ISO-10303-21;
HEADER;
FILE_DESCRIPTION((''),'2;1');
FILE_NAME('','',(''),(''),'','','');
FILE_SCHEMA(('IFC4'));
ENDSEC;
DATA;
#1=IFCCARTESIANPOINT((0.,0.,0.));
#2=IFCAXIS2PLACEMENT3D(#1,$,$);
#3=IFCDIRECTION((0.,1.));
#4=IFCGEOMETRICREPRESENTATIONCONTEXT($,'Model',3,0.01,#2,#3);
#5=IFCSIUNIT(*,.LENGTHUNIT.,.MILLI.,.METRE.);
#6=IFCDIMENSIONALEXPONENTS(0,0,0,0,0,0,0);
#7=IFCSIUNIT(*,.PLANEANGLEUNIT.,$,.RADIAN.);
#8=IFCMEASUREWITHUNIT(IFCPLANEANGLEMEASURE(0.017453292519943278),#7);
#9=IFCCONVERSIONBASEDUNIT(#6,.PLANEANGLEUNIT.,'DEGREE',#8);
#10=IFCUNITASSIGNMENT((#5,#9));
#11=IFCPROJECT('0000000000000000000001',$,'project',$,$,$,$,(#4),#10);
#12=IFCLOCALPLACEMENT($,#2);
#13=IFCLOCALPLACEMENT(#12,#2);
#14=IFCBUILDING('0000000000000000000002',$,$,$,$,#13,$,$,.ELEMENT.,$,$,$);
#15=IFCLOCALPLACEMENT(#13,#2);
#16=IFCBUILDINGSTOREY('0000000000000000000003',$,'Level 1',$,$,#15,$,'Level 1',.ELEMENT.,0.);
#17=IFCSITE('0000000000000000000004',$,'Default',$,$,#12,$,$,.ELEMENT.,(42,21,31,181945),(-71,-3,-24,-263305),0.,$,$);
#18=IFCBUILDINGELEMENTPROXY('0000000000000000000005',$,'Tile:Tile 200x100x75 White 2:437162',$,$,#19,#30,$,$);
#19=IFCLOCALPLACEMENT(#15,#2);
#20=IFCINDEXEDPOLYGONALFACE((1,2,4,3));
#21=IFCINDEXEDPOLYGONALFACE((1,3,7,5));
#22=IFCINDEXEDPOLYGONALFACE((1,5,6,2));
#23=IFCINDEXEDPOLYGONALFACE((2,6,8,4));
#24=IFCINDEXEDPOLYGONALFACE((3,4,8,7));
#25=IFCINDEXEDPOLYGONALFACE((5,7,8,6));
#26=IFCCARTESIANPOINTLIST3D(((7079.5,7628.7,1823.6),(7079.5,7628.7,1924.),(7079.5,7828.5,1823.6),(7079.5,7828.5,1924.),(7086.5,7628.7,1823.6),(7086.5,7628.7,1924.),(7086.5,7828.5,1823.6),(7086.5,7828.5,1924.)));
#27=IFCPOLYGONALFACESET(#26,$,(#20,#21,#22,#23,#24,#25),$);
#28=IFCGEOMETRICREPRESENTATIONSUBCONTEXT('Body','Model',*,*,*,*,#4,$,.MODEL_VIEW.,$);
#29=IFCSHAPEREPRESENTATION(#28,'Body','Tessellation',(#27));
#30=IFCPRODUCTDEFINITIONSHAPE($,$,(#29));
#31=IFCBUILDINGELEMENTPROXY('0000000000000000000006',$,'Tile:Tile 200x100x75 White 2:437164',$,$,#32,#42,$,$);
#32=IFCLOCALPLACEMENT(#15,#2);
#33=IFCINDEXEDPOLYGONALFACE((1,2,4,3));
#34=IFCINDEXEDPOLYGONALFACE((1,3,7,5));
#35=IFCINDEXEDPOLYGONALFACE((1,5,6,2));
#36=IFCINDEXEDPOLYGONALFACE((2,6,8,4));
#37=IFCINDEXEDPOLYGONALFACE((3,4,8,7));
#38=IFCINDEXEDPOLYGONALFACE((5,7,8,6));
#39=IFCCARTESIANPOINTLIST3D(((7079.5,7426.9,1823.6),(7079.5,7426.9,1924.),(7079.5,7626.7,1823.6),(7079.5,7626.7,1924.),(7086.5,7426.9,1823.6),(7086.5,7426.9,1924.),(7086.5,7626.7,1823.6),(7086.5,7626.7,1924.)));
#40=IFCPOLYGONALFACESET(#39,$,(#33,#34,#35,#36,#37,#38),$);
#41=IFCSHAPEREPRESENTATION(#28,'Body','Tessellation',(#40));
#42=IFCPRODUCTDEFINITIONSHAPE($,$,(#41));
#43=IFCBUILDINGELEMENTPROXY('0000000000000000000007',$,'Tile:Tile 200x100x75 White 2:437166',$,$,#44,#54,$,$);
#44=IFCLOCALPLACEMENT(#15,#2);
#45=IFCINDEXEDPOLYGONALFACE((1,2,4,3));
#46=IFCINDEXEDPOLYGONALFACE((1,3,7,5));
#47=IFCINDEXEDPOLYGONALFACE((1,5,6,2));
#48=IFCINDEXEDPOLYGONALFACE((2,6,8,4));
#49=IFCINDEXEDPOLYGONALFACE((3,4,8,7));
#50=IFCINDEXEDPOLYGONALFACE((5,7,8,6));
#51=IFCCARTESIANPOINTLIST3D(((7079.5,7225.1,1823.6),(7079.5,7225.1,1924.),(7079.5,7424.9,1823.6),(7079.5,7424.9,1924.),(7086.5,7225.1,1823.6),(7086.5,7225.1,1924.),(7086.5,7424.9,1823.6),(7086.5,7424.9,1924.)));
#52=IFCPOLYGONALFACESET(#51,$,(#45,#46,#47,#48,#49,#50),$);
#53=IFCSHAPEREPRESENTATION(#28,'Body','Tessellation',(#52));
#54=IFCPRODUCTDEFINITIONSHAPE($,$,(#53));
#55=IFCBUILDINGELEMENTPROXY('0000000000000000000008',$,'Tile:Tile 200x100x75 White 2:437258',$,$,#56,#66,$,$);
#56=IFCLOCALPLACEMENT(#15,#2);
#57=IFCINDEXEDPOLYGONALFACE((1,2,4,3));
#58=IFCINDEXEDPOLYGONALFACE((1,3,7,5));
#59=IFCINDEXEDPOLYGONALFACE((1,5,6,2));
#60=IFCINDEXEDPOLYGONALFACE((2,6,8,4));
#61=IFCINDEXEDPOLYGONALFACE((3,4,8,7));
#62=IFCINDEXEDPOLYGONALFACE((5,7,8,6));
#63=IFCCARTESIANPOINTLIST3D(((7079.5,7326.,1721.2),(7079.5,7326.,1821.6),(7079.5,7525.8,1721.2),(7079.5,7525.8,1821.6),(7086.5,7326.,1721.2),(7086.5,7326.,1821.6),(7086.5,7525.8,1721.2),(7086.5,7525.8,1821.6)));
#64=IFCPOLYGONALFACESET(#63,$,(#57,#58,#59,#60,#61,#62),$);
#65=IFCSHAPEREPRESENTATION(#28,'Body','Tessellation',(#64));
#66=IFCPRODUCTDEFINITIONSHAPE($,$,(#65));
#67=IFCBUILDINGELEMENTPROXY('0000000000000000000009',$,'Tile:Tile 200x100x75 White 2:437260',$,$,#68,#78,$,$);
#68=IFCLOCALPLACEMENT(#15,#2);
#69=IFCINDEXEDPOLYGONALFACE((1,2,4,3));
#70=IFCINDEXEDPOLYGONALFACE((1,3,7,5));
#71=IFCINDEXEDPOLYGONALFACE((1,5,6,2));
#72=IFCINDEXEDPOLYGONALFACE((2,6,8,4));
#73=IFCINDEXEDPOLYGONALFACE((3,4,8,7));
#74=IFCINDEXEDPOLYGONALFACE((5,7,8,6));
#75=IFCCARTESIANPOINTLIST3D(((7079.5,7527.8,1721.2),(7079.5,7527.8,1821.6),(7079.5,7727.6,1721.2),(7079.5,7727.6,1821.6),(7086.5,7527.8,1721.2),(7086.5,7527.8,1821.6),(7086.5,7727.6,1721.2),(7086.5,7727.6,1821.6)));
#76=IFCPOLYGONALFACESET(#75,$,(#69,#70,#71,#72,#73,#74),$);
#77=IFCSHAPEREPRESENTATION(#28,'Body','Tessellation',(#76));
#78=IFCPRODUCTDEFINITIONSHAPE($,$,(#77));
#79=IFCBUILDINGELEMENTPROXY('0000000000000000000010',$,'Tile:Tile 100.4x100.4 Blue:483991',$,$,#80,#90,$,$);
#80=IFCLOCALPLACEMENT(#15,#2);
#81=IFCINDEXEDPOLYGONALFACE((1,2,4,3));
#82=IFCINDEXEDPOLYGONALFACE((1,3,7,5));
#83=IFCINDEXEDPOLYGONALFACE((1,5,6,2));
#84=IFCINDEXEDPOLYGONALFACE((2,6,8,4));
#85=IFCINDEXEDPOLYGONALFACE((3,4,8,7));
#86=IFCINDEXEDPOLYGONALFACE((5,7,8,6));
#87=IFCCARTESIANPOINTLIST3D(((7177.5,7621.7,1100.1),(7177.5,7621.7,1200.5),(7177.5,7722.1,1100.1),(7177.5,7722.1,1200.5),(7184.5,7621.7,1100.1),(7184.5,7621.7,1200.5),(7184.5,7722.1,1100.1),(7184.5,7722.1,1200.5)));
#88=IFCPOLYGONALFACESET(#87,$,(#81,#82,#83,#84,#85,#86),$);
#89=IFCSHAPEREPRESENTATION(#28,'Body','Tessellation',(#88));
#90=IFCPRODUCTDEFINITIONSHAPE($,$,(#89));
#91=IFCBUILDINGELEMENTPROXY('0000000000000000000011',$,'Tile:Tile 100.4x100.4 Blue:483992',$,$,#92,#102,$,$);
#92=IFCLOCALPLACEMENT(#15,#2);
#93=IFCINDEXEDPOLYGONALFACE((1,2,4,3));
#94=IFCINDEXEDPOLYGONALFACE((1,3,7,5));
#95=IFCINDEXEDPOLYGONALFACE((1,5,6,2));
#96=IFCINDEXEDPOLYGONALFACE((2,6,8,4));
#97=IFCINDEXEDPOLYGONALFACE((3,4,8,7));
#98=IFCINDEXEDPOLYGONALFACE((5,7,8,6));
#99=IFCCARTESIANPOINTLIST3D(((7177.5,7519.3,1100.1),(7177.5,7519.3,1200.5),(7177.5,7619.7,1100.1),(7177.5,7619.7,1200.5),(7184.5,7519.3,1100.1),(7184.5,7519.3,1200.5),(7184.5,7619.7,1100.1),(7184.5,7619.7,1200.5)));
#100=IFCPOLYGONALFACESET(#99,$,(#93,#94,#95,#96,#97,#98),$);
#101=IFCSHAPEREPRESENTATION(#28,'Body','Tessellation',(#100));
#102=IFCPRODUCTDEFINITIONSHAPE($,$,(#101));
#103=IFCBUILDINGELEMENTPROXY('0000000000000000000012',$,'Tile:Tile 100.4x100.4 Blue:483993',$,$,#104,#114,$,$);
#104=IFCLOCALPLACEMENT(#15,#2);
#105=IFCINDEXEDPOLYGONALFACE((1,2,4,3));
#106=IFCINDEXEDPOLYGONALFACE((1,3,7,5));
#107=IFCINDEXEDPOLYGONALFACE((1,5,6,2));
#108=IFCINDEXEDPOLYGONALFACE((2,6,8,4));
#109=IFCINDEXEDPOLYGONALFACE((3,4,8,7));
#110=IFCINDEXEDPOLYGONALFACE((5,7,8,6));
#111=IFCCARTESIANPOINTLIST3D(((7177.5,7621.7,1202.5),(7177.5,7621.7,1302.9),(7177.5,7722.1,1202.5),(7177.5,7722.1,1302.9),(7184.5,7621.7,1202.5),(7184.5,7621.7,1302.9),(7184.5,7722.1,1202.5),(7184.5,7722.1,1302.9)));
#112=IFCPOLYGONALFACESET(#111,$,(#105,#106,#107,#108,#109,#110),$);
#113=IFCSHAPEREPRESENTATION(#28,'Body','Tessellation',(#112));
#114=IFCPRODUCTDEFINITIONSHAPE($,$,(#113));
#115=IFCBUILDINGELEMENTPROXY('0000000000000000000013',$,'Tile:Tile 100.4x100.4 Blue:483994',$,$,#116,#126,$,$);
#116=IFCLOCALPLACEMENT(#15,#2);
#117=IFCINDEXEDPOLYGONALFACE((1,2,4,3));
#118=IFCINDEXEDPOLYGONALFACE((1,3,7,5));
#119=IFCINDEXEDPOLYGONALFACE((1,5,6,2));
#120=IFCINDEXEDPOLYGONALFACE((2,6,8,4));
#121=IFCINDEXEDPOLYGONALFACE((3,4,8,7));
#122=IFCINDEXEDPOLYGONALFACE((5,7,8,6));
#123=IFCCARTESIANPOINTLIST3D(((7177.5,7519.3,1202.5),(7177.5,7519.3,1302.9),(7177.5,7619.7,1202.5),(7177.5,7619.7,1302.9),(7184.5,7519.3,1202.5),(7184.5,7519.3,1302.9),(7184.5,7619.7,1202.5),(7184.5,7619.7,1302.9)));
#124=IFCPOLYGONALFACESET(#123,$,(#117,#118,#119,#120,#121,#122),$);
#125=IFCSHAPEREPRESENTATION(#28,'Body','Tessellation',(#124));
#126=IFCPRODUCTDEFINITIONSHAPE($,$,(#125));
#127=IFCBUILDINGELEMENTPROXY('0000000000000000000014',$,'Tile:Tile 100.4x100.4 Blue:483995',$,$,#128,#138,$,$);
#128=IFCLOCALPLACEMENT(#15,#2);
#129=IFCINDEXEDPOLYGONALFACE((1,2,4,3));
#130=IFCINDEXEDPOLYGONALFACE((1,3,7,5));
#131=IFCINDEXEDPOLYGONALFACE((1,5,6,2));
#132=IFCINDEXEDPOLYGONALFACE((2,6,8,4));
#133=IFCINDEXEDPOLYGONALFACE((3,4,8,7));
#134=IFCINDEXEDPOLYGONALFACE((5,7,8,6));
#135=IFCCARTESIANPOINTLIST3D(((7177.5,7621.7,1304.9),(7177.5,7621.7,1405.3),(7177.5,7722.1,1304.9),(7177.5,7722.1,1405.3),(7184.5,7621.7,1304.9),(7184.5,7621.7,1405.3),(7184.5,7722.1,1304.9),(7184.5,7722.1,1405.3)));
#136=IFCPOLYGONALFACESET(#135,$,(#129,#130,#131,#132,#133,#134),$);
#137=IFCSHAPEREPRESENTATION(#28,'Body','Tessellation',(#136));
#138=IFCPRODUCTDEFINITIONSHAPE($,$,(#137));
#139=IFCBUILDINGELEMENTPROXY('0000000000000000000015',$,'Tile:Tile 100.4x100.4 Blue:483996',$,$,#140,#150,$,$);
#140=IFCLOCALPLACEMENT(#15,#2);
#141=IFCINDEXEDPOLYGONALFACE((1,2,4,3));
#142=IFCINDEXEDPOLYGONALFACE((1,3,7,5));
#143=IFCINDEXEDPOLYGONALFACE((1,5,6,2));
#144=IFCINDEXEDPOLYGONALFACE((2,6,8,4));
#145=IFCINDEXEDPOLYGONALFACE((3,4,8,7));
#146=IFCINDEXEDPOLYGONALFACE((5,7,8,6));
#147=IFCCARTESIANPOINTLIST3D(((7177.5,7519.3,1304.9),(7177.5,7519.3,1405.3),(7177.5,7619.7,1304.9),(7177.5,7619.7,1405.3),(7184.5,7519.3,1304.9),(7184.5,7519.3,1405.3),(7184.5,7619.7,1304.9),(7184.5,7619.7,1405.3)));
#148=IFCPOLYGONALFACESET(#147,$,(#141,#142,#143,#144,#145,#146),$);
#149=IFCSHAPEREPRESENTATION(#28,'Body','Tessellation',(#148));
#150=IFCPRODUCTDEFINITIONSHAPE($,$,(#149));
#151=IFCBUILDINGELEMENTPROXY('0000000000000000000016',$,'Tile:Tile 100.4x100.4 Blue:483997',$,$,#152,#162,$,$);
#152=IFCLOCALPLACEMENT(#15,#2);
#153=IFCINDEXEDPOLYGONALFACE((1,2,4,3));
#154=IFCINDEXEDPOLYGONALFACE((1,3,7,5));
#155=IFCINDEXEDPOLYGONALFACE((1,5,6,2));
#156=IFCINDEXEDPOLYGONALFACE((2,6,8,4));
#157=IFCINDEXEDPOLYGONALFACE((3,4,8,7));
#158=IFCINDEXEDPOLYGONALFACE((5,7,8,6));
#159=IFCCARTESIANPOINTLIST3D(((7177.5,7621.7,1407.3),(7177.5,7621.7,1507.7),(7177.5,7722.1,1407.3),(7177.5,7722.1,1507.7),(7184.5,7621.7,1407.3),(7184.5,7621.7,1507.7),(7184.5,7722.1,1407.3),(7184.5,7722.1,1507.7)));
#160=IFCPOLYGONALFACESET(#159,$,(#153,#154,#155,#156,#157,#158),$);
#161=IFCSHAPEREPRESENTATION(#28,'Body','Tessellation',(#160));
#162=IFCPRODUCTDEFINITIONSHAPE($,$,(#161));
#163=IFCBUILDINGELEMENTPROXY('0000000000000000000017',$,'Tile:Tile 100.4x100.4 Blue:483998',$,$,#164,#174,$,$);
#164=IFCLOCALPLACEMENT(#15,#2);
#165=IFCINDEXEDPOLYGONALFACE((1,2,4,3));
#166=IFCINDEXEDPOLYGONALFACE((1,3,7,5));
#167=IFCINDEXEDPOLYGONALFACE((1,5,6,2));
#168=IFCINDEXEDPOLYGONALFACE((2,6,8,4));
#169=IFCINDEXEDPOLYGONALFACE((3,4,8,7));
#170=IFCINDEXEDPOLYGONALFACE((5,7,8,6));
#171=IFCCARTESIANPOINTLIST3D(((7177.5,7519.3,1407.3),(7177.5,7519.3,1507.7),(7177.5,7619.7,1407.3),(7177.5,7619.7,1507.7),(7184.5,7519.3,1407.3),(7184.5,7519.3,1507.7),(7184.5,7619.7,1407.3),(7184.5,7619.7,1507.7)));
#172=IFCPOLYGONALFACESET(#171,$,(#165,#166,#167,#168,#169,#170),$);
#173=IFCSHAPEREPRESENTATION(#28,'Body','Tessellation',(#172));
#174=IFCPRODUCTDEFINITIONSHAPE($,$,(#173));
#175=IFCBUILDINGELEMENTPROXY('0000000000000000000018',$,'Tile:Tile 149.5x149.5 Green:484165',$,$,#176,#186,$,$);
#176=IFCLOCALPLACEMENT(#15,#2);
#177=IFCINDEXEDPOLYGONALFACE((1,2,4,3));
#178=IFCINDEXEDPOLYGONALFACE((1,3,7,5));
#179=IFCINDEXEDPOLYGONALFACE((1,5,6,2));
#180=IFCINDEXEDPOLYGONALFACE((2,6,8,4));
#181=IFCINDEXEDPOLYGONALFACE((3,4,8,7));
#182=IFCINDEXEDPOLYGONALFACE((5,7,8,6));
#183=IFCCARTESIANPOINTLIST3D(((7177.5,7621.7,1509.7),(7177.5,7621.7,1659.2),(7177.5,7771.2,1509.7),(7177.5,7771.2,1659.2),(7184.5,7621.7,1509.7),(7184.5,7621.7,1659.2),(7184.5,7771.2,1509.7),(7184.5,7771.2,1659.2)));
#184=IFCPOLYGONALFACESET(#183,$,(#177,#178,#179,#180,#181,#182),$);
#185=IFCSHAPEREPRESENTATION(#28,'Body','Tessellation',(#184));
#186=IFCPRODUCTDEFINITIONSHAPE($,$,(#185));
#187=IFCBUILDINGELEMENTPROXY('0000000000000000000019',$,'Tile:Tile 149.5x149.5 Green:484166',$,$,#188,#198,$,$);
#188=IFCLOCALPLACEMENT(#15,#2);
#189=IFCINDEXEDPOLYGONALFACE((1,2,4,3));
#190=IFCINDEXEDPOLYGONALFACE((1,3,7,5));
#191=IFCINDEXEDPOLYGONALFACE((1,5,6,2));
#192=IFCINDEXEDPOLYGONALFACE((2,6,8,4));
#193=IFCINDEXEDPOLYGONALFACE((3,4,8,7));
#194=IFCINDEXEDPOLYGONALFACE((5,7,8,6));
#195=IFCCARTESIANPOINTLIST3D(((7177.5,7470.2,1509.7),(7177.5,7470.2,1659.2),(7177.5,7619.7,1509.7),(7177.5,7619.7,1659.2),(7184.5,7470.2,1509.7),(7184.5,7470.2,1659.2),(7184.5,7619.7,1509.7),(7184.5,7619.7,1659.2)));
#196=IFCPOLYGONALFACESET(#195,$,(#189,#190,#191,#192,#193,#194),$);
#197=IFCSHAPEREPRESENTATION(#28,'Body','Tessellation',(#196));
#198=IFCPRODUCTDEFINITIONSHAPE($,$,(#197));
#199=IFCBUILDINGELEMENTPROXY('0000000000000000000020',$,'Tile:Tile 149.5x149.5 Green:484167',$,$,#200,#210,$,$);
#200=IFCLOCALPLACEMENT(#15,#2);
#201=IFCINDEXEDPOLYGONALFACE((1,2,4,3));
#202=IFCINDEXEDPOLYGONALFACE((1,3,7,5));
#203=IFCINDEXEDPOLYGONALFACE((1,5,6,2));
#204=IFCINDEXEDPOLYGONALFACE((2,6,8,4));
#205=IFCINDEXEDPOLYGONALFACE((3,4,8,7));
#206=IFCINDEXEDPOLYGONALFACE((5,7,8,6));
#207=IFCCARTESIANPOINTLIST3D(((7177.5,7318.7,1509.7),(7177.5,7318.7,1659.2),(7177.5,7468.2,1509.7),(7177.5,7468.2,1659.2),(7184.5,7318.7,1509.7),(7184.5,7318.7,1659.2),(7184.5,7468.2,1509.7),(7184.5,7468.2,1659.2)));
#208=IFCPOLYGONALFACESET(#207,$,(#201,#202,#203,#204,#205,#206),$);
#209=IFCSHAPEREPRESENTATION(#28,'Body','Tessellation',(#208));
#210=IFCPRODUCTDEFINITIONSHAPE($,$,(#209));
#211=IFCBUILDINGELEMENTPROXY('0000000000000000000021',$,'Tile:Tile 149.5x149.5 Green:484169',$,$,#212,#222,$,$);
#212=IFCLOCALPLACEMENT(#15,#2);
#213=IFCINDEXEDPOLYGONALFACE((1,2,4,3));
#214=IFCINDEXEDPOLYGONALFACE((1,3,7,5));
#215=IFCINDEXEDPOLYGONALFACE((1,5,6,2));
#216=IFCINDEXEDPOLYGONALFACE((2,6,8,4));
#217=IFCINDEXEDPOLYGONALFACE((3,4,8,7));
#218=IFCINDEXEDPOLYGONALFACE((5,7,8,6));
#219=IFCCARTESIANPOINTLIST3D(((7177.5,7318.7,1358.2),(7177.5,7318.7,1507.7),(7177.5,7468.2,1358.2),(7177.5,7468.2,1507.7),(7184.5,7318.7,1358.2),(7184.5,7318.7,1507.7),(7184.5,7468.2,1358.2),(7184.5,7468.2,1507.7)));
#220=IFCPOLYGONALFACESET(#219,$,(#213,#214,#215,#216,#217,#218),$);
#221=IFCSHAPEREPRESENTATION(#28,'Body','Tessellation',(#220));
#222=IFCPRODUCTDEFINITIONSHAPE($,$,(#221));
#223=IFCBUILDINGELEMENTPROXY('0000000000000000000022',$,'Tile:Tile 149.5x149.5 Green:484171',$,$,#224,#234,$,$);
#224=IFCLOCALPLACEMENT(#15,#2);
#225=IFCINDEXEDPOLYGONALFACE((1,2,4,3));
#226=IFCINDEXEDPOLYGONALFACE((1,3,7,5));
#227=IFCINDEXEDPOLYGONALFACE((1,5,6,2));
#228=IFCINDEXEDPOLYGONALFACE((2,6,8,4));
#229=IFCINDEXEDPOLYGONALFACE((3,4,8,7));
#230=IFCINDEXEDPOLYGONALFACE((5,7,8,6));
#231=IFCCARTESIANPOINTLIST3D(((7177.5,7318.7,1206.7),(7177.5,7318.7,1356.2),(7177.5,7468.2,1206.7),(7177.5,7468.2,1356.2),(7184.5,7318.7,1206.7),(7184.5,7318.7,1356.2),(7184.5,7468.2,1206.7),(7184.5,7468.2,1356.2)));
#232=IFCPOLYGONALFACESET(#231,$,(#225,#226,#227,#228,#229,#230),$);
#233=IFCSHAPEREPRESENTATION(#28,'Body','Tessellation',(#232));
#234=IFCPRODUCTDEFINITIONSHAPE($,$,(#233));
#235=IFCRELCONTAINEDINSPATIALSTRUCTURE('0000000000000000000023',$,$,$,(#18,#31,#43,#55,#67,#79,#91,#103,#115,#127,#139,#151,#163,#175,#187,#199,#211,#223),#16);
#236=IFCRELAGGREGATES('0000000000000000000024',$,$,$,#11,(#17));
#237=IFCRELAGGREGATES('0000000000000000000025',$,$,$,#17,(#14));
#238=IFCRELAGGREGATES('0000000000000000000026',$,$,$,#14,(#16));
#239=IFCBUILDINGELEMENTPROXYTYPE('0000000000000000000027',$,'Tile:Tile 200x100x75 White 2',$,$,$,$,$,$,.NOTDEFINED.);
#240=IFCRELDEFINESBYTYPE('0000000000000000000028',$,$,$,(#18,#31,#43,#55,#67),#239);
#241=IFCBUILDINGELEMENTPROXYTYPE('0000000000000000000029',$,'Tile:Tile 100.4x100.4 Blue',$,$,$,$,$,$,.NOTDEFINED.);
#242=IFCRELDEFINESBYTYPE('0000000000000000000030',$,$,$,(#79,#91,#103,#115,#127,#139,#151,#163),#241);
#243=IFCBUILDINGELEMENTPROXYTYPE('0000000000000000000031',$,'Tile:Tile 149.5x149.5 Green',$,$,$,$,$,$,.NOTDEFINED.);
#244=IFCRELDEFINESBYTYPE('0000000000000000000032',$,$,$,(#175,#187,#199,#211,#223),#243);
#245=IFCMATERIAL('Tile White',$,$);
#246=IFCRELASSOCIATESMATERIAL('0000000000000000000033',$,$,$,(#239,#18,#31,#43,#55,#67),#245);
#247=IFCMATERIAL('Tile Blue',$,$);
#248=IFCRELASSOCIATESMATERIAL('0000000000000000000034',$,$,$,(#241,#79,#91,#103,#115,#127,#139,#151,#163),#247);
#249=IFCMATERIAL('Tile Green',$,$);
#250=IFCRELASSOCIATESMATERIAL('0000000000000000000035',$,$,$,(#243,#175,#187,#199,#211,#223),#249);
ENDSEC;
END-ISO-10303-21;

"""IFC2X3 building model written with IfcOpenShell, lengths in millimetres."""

from ifc_helpers import new_model, entity, si_unit, converted_unit, direction, frame, frame_2d, origin, origin_2d_with_axis, place, context, subcontext, project, spatial, rectangle, extrude, source, transform, mapped, material, type_object, type_shapes, element, save


model = new_model("IFC2X3")

# Units and contexts
model_context = context("Model", 3, precision=0.01, world=origin(), true_north=direction((0.0, 1.0)))
body_context = subcontext(model_context, "Body", "Model", "MODEL_VIEW")
ifc_project = project(units=[si_unit("LENGTHUNIT", "METRE", prefix="MILLI"), converted_unit("PLANEANGLEUNIT", "DEGREE", entity("IfcPlaneAngleMeasure", 0.017453292519943278), si_unit("PLANEANGLEUNIT", "RADIAN"), dimensions=[0, 0, 0, 0, 0, 0, 0])], contexts=[model_context])

# Site, building, storey
site_placement = place(None, origin())
site = spatial("IfcSite", under=ifc_project, at=site_placement, Name="Default", CompositionType="ELEMENT", RefLatitude=(42, 21, 31, 181945), RefLongitude=(-71, -3, -24, -263305), RefElevation=0.0)
building_placement = place(site_placement, origin())
building = spatial("IfcBuilding", under=site, at=building_placement, CompositionType="ELEMENT")
storey_placement = place(building_placement, origin())
storey = spatial("IfcBuildingStorey", under=building, at=storey_placement, Name="Level 1", LongName="Level 1", CompositionType="ELEMENT", Elevation=0.0)

# Building element proxies
ifc_material_1 = material(Name="Tile White")
building_element_proxy_type_1 = type_object("IfcBuildingElementProxyType", Name="Tile:Tile 200x100x75 White 2", PredefinedType="NOTDEFINED", material=ifc_material_1)
shared_shape_1 = source(origin(), body_context, "Body", "SweptSolid", [
    extrude(rectangle(XDim=199.8, YDim=100.4, at=frame_2d((0.0, 0.0), x_axis=(1.0, 0.0))), frame((-50.2, -99.9, 0.0), z_axis=(0.0, 0.0, 1.0), x_axis=(0.0, -1.0, 0.0)), (0.0, 0.0, 1.0), 7.0),
])
type_shapes(building_element_proxy_type_1, [shared_shape_1])
for number, where, z_axis, x_axis, name in (
    (1, (7086.5, 7828.5, 1924.0), (-1.0, 0.0, 0.0), (0.0, 0.0, 1.0), "Tile:Tile 200x100x75 White 2:437162"),
    (2, (7086.5, 7626.7, 1924.0), (-1.0, 0.0, 0.0), (0.0, 0.0, 1.0), "Tile:Tile 200x100x75 White 2:437164"),
    (3, (7086.5, 7424.9, 1924.0), (-1.0, 0.0, 0.0), (0.0, 0.0, 1.0), "Tile:Tile 200x100x75 White 2:437166"),
    (4, (7086.5, 7525.8, 1821.6), (-1.0, 0.0, 0.0), (0.0, 0.0, 1.0), "Tile:Tile 200x100x75 White 2:437258"),
    (5, (7086.5, 7727.6, 1821.6), (-1.0, 0.0, 0.0), (0.0, 0.0, 1.0), "Tile:Tile 200x100x75 White 2:437260"),
):
    element("IfcBuildingElementProxy", number, at=place(storey_placement, frame(where, z_axis=z_axis, x_axis=x_axis)), inside=storey, type_object=building_element_proxy_type_1, material=ifc_material_1, Name=name, context=body_context, shape_type="MappedRepresentation", body=[
        mapped(shared_shape_1, transform((0.0, 0.0, 0.0), scale=1.0)),
    ])
ifc_material_2 = material(Name="Tile Blue")
building_element_proxy_type_2 = type_object("IfcBuildingElementProxyType", Name="Tile:Tile 100.4x100.4 Blue", PredefinedType="NOTDEFINED", material=ifc_material_2)
shared_shape_2 = source(origin(), body_context, "Body", "SweptSolid", [
    extrude(rectangle(XDim=100.4, YDim=100.4, at=origin_2d_with_axis()), frame((-50.2, -50.2, 0.0), z_axis=(0.0, 0.0, 1.0), x_axis=(0.0, -1.0, 0.0)), (0.0, 0.0, 1.0), 7.0),
])
type_shapes(building_element_proxy_type_2, [shared_shape_2])
for number, where, z_axis, x_axis, name in (
    (6, (7184.5, 7722.1, 1100.1), (-1.0, 0.0, 0.0), (0.0, 1.0, 0.0), "Tile:Tile 100.4x100.4 Blue:483991"),
    (7, (7184.5, 7619.7, 1100.1), (-1.0, 0.0, 0.0), (0.0, 1.0, 0.0), "Tile:Tile 100.4x100.4 Blue:483992"),
    (8, (7184.5, 7722.1, 1202.5), (-1.0, 0.0, 0.0), (0.0, 1.0, 0.0), "Tile:Tile 100.4x100.4 Blue:483993"),
    (9, (7184.5, 7619.7, 1202.5), (-1.0, 0.0, 0.0), (0.0, 1.0, 0.0), "Tile:Tile 100.4x100.4 Blue:483994"),
    (10, (7184.5, 7722.1, 1304.9), (-1.0, 0.0, 0.0), (0.0, 1.0, 0.0), "Tile:Tile 100.4x100.4 Blue:483995"),
    (11, (7184.5, 7619.7, 1304.9), (-1.0, 0.0, 0.0), (0.0, 1.0, 0.0), "Tile:Tile 100.4x100.4 Blue:483996"),
    (12, (7184.5, 7722.1, 1407.3), (-1.0, 0.0, 0.0), (0.0, 1.0, 0.0), "Tile:Tile 100.4x100.4 Blue:483997"),
    (13, (7184.5, 7619.7, 1407.3), (-1.0, 0.0, 0.0), (0.0, 1.0, 0.0), "Tile:Tile 100.4x100.4 Blue:483998"),
):
    element("IfcBuildingElementProxy", number, at=place(storey_placement, frame(where, z_axis=z_axis, x_axis=x_axis)), inside=storey, type_object=building_element_proxy_type_2, material=ifc_material_2, Name=name, context=body_context, shape_type="MappedRepresentation", body=[
        mapped(shared_shape_2, transform((0.0, 0.0, 0.0), scale=1.0)),
    ])
ifc_material_3 = material(Name="Tile Green")
building_element_proxy_type_3 = type_object("IfcBuildingElementProxyType", Name="Tile:Tile 149.5x149.5 Green", PredefinedType="NOTDEFINED", material=ifc_material_3)
shared_shape_3 = source(origin(), body_context, "Body", "SweptSolid", [
    extrude(rectangle(XDim=149.5, YDim=149.5, at=origin_2d_with_axis()), frame((-74.7, -74.8, 0.0), z_axis=(0.0, 0.0, 1.0), x_axis=(0.0, -1.0, 0.0)), (0.0, 0.0, 1.0), 7.0),
])
type_shapes(building_element_proxy_type_3, [shared_shape_3])
for number, where, z_axis, x_axis, name in (
    (14, (7184.5, 7771.2, 1659.2), (-1.0, 0.0, 0.0), (0.0, 0.0, 1.0), "Tile:Tile 149.5x149.5 Green:484165"),
    (15, (7184.5, 7619.7, 1659.2), (-1.0, 0.0, 0.0), (0.0, 0.0, 1.0), "Tile:Tile 149.5x149.5 Green:484166"),
    (16, (7184.5, 7468.2, 1659.2), (-1.0, 0.0, 0.0), (0.0, 0.0, 1.0), "Tile:Tile 149.5x149.5 Green:484167"),
    (17, (7184.5, 7468.2, 1507.7), (-1.0, 0.0, 0.0), (0.0, 0.0, 1.0), "Tile:Tile 149.5x149.5 Green:484169"),
    (18, (7184.5, 7468.2, 1356.2), (-1.0, 0.0, 0.0), (0.0, 0.0, 1.0), "Tile:Tile 149.5x149.5 Green:484171"),
):
    element("IfcBuildingElementProxy", number, at=place(storey_placement, frame(where, z_axis=z_axis, x_axis=x_axis)), inside=storey, type_object=building_element_proxy_type_3, material=ifc_material_3, Name=name, context=body_context, shape_type="MappedRepresentation", body=[
        mapped(shared_shape_3, transform((0.0, 0.0, 0.0), scale=1.0)),
    ])

save(model, "model.ifc")
